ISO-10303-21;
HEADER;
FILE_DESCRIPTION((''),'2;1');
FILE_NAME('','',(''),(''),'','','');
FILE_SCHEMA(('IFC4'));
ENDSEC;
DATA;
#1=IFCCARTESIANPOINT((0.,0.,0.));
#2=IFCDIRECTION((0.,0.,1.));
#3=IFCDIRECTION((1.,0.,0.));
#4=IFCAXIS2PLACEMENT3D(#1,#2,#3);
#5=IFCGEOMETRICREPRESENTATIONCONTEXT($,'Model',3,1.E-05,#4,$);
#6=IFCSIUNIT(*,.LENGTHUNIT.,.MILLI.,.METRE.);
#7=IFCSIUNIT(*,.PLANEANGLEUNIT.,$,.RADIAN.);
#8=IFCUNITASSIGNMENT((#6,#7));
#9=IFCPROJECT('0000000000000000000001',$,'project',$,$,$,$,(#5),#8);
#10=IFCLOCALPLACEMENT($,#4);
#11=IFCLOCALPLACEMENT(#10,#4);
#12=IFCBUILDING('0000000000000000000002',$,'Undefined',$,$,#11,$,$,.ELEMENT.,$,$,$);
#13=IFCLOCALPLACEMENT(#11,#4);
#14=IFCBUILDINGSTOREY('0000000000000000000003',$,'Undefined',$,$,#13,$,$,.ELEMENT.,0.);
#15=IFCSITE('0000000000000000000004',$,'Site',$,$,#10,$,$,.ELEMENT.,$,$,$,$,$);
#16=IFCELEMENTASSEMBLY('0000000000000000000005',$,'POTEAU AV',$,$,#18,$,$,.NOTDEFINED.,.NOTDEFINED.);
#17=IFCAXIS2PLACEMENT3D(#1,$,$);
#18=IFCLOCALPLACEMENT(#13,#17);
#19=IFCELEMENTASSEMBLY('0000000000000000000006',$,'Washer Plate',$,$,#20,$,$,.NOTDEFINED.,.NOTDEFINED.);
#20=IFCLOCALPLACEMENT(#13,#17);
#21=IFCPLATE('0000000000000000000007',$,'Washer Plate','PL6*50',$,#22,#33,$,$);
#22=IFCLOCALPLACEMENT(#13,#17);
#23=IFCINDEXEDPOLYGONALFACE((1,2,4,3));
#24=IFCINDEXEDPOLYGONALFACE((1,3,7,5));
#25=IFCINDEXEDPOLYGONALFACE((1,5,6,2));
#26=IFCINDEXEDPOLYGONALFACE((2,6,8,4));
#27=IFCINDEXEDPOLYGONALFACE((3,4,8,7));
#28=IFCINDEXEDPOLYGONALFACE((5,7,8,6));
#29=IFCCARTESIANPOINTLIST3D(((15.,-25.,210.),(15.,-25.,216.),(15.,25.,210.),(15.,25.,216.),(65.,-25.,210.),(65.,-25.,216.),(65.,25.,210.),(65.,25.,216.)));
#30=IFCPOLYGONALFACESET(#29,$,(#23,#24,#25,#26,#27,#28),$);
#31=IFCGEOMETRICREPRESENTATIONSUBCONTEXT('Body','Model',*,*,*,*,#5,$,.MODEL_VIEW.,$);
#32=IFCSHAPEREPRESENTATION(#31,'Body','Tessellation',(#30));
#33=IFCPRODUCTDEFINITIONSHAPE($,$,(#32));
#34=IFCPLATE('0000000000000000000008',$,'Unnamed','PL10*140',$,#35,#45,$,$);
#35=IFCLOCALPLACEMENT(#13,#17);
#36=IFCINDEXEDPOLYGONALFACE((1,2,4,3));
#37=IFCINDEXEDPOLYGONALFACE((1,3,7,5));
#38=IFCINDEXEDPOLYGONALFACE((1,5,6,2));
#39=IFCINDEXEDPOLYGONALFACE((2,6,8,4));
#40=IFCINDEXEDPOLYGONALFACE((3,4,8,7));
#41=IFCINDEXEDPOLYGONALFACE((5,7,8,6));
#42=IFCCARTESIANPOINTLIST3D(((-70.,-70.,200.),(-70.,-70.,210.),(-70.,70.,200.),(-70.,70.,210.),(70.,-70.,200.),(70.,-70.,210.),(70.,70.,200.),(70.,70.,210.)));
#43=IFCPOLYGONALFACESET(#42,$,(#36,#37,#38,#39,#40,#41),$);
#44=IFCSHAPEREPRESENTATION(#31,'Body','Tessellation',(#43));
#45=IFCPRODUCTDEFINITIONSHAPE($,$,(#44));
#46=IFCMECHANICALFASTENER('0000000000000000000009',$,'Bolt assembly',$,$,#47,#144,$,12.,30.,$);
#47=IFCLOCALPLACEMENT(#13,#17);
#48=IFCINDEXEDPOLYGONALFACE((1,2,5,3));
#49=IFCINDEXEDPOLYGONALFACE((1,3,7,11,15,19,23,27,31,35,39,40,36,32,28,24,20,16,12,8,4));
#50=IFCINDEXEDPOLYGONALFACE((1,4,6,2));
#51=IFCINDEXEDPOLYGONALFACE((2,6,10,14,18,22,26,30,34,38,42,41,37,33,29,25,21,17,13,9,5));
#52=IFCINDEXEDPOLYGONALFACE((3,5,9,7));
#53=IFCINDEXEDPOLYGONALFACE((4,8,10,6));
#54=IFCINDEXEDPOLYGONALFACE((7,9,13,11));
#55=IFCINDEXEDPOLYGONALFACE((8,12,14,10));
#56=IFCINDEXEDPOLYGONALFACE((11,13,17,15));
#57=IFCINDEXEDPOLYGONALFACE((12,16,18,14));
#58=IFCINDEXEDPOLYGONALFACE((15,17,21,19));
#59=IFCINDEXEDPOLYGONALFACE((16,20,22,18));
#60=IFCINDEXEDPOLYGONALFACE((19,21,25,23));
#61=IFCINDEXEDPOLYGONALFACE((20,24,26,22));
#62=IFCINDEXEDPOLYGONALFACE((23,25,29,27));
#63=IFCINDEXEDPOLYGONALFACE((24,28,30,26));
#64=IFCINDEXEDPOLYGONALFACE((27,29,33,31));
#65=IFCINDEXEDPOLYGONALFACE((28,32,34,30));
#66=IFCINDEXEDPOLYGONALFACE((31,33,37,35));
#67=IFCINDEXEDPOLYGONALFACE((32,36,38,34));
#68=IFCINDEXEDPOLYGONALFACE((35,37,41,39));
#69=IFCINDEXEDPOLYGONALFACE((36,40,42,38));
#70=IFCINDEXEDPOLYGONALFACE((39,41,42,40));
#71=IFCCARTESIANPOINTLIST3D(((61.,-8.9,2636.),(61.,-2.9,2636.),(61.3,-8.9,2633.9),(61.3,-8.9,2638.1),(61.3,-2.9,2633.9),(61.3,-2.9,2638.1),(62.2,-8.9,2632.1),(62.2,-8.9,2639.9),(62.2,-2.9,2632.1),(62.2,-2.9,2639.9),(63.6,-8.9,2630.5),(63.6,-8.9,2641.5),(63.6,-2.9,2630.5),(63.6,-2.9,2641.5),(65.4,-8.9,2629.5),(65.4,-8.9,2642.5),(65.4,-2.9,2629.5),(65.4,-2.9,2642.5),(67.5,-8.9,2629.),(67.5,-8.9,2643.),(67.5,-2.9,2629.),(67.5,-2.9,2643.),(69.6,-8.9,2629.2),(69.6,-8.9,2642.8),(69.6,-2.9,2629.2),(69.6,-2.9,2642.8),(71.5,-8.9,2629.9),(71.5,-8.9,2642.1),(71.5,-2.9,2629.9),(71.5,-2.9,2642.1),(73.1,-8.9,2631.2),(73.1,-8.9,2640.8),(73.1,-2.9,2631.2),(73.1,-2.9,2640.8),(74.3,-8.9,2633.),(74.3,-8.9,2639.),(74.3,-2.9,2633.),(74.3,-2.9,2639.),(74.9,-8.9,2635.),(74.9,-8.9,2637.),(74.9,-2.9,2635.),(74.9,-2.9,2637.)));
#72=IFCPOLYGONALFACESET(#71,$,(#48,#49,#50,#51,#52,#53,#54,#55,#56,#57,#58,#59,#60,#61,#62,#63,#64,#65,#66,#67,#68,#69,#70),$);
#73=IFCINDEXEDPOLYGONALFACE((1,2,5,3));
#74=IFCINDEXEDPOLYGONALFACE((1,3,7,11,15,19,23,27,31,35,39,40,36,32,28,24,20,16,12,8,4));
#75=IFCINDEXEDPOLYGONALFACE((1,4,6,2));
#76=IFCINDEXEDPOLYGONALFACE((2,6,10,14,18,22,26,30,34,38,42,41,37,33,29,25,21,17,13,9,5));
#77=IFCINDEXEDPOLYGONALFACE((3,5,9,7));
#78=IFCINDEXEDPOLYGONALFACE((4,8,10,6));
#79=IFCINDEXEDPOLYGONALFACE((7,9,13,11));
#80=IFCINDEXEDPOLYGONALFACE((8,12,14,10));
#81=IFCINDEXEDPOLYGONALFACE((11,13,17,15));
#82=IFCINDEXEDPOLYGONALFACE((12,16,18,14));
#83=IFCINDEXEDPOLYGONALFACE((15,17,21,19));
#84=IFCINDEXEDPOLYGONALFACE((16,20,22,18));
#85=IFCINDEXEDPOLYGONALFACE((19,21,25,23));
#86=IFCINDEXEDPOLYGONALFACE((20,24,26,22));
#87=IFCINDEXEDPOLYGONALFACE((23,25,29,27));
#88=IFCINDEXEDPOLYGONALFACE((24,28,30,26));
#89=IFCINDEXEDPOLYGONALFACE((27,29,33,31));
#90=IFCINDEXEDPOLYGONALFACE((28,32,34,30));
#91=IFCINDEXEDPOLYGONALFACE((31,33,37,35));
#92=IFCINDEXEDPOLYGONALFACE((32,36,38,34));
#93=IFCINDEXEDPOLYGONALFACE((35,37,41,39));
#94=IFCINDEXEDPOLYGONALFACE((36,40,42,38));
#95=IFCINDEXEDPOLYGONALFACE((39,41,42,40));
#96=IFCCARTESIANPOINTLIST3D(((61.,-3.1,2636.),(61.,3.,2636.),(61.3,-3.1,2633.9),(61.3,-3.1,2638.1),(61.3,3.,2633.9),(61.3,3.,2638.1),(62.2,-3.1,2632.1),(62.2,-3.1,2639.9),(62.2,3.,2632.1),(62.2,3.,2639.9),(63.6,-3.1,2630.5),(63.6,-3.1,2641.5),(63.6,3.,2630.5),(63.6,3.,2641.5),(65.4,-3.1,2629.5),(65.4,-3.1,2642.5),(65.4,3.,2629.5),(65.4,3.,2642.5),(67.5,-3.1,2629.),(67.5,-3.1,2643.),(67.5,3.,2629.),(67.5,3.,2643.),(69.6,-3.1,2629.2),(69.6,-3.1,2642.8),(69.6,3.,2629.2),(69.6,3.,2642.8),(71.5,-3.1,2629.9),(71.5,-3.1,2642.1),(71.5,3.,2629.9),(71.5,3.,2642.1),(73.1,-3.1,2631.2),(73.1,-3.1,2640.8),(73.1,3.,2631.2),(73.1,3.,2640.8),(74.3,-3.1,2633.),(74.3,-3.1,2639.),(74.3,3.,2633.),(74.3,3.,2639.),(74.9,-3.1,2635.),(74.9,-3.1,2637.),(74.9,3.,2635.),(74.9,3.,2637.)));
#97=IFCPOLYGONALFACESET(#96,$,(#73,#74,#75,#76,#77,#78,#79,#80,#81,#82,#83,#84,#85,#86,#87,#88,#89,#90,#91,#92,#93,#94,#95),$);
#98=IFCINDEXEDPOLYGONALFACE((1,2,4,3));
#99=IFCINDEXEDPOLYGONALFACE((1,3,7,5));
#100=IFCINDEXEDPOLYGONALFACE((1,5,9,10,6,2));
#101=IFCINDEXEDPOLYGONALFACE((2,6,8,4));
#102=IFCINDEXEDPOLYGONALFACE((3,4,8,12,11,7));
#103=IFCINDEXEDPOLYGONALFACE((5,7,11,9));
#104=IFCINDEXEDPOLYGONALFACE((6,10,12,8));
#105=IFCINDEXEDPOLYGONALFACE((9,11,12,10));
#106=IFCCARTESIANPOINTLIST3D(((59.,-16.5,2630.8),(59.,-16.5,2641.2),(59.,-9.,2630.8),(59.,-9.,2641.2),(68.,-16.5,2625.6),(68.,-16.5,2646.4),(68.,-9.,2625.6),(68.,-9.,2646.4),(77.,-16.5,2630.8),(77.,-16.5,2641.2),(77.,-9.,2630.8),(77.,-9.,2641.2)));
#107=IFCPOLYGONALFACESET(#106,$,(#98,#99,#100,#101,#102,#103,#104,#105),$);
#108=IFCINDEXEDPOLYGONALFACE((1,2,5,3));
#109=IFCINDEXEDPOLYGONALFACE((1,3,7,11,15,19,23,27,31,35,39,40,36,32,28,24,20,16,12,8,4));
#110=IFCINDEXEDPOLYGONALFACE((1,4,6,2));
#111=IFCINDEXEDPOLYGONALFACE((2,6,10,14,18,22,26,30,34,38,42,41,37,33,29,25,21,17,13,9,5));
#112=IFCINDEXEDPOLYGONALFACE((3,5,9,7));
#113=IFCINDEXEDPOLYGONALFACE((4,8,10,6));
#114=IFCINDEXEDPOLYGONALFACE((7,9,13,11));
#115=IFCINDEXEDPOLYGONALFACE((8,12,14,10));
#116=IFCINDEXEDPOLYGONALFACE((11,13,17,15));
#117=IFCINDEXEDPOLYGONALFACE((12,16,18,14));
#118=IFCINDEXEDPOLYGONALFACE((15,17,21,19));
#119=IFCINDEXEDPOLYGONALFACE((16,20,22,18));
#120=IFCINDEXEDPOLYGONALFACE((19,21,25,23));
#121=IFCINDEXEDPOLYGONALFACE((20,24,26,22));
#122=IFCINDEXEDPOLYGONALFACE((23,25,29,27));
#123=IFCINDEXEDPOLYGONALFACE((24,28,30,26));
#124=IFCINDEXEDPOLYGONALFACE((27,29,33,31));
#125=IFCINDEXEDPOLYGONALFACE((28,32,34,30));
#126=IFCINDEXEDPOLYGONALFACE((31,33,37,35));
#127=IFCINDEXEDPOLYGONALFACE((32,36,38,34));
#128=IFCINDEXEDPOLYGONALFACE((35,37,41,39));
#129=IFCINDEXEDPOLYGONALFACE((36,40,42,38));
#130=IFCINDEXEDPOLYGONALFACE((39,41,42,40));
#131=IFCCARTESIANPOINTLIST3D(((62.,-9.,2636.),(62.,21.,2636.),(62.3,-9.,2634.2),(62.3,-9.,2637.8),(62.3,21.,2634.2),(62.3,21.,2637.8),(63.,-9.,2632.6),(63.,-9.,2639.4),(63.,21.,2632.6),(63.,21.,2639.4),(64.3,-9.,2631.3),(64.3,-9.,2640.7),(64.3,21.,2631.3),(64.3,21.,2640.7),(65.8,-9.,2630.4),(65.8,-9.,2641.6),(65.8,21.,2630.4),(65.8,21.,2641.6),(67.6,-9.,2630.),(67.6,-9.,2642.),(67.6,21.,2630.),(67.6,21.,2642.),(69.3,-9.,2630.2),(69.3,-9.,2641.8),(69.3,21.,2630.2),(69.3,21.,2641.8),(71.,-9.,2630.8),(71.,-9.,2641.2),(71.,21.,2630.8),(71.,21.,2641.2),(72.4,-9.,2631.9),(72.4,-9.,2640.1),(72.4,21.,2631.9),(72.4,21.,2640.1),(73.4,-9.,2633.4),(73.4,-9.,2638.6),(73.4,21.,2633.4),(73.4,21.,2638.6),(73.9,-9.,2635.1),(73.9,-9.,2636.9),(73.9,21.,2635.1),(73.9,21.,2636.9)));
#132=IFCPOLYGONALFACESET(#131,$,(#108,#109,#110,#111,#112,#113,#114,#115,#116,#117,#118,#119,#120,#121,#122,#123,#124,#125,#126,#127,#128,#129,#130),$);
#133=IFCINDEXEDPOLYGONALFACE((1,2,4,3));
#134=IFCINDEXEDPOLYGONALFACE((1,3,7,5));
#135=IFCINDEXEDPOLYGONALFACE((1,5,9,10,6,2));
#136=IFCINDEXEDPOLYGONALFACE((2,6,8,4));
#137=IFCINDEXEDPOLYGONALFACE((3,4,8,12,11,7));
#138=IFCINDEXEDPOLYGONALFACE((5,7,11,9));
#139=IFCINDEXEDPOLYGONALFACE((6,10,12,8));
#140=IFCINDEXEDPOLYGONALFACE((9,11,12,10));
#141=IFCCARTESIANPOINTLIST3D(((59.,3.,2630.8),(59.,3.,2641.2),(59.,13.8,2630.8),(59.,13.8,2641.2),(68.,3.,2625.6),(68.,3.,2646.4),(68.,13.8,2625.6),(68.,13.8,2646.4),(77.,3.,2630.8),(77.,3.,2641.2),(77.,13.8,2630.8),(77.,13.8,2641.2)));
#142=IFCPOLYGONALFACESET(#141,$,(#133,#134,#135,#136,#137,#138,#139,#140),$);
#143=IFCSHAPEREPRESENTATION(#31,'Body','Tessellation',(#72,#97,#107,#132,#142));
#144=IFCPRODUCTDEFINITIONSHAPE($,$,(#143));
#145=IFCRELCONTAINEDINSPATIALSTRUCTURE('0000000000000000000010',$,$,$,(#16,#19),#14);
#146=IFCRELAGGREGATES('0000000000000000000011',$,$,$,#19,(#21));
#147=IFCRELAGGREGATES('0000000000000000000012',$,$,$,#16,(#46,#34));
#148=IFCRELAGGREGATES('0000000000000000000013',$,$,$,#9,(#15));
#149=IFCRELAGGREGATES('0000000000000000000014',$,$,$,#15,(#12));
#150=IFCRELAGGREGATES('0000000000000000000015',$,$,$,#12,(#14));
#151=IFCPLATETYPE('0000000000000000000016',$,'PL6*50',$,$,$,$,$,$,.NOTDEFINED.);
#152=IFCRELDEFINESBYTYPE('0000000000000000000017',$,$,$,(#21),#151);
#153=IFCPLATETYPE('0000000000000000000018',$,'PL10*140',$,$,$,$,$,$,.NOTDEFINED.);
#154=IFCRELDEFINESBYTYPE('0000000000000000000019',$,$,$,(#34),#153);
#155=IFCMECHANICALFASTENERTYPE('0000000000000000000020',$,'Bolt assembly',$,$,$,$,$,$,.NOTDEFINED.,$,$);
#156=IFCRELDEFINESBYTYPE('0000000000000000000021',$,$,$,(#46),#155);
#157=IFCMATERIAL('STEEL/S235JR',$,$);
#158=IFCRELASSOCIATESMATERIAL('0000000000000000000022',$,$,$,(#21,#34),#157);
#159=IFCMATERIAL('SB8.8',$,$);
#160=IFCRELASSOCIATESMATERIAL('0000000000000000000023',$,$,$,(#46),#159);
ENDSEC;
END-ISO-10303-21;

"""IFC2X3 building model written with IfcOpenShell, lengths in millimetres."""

from ifc_helpers import new_model, si_unit, frame, origin_with_axes, origin_2d_with_axis, place, context, subcontext, project, spatial, polyline, circle, outline, extrude, source, transform, mapped, material, type_object, element, aggregate, save


model = new_model("IFC2X3")

# Units and contexts
model_context = context("Model", 3, precision=1e-05, world=origin_with_axes())
body_context = subcontext(model_context, "Body", "Model", "MODEL_VIEW")
ifc_project = project(units=[si_unit("LENGTHUNIT", "METRE", prefix="MILLI"), si_unit("PLANEANGLEUNIT", "RADIAN")], contexts=[model_context])

# Site, building, storey
site_placement = place(None, origin_with_axes())
site = spatial("IfcSite", under=ifc_project, at=site_placement, Name="Site", CompositionType="ELEMENT")
building_placement = place(site_placement, origin_with_axes())
building = spatial("IfcBuilding", under=site, at=building_placement, Name="Undefined", CompositionType="ELEMENT")
storey_placement = place(building_placement, origin_with_axes())
storey = spatial("IfcBuildingStorey", under=building, at=storey_placement, Name="Undefined", CompositionType="ELEMENT", Elevation=0.0)

# Shared definitions
ifc_material_1 = material(Name="STEEL/S235JR")

# Element assembly
assembly_1_placement = place(storey_placement, origin_with_axes())
assembly_1 = element("IfcElementAssembly", 1, at=assembly_1_placement, inside=storey, Name="POTEAU AV", AssemblyPlace="NOTDEFINED", PredefinedType="NOTDEFINED")

# Element assembly, plate
plate_type_1 = type_object("IfcPlateType", Name="PL6*50", PredefinedType="NOTDEFINED")
assembly_2_placement = place(storey_placement, origin_with_axes())
assembly_2 = element("IfcElementAssembly", 2, at=assembly_2_placement, inside=storey, Name="Washer Plate", AssemblyPlace="NOTDEFINED", PredefinedType="NOTDEFINED")
plate_1_placement = place(assembly_2_placement, frame((65.0, 25.0, 213.0), z_axis=(0.0, 0.0, -1.0), x_axis=(0.0, -1.0, 0.0)))
plate_1 = element("IfcPlate", 3, at=plate_1_placement, type_object=plate_type_1, material=ifc_material_1, Name="Washer Plate", Description="PL6*50", context=body_context, shape_type="SweptSolid", body=[
    extrude(outline(polyline([(0.0, 0.0), (50.0, 0.0), (50.0, 50.0), (0.0, 50.0), (0.0, 0.0)])), frame((0.0, 0.0, -3.0), z_axis=(0.0, 0.0, 1.0), x_axis=(1.0, 0.0, 0.0)), (0.0, 0.0, 1.0), 6.0),
])

# Plate
plate_type_2 = type_object("IfcPlateType", Name="PL10*140", PredefinedType="NOTDEFINED")
plate_2_placement = place(assembly_1_placement, frame((0.0, -70.0, 205.0), z_axis=(0.0, 0.0, 1.0), x_axis=(0.0, 1.0, 0.0)))
plate_2 = element("IfcPlate", 4, at=plate_2_placement, type_object=plate_type_2, material=ifc_material_1, Name="Unnamed", Description="PL10*140", context=body_context, shape_type="SweptSolid", body=[
    extrude(outline(polyline([(0.0, 70.0), (140.0, 70.0), (140.0, -70.0), (0.0, -70.0), (0.0, 70.0)])), frame((0.0, 0.0, -5.0), z_axis=(0.0, 0.0, 1.0), x_axis=(1.0, 0.0, 0.0)), (0.0, 0.0, 1.0), 10.0),
])

# Mechanical fastener
ifc_material_2 = material(Name="SB8.8")
mechanical_fastener_type = type_object("IfcMechanicalFastenerType", Name="Bolt assembly")
shared_shape_1 = source(origin_with_axes(), body_context, "Body", "SweptSolid", [
    extrude(circle(Radius=7.0, at=origin_2d_with_axis()), frame((0.0, -8.9, 0.0), z_axis=(0.0, 1.0, 0.0), x_axis=(1.0, 0.0, 0.0)), (0.0, 0.0, 1.0), 6.0),
    extrude(circle(Radius=7.0, at=origin_2d_with_axis()), frame((0.0, -3.1, 0.0), z_axis=(0.0, 1.0, 0.0), x_axis=(1.0, 0.0, 0.0)), (0.0, 0.0, 1.0), 6.1),
    extrude(outline(polyline([(9.0, -5.2), (9.0, 5.2), (0.0, 10.4), (-9.0, 5.2), (-9.0, -5.2), (0.0, -10.4), (9.0, -5.2)])), frame((0.0, -16.5, 0.0), z_axis=(0.0, 1.0, 0.0), x_axis=(1.0, 0.0, 0.0)), (0.0, 0.0, 1.0), 7.5),
    extrude(circle(Radius=6.0, at=origin_2d_with_axis()), frame((0.0, -9.0, 0.0), z_axis=(0.0, 1.0, 0.0), x_axis=(1.0, 0.0, 0.0)), (0.0, 0.0, 1.0), 30.0),
    extrude(outline(polyline([(9.0, -5.2), (9.0, 5.2), (0.0, 10.4), (-9.0, 5.2), (-9.0, -5.2), (0.0, -10.4), (9.0, -5.2)])), frame((0.0, 3.0, 0.0), z_axis=(0.0, 1.0, 0.0), x_axis=(1.0, 0.0, 0.0)), (0.0, 0.0, 1.0), 10.8),
])
mechanical_fastener_1_placement = place(assembly_1_placement, frame((68.0, 0.0, 2636.0), z_axis=(0.0, 0.0, -1.0), x_axis=(-1.0, 0.0, 0.0)))
mechanical_fastener_1 = element("IfcMechanicalFastener", 5, at=mechanical_fastener_1_placement, type_object=mechanical_fastener_type, material=ifc_material_2, Name="Bolt assembly", NominalDiameter=12.0, NominalLength=30.0, context=body_context, shape_type="MappedRepresentation", body=[
    mapped(shared_shape_1, transform((0.0, 0.0, 0.0))),
])

aggregate(assembly_2, [plate_1])
aggregate(assembly_1, [mechanical_fastener_1, plate_2])

save(model, "model.ifc")
